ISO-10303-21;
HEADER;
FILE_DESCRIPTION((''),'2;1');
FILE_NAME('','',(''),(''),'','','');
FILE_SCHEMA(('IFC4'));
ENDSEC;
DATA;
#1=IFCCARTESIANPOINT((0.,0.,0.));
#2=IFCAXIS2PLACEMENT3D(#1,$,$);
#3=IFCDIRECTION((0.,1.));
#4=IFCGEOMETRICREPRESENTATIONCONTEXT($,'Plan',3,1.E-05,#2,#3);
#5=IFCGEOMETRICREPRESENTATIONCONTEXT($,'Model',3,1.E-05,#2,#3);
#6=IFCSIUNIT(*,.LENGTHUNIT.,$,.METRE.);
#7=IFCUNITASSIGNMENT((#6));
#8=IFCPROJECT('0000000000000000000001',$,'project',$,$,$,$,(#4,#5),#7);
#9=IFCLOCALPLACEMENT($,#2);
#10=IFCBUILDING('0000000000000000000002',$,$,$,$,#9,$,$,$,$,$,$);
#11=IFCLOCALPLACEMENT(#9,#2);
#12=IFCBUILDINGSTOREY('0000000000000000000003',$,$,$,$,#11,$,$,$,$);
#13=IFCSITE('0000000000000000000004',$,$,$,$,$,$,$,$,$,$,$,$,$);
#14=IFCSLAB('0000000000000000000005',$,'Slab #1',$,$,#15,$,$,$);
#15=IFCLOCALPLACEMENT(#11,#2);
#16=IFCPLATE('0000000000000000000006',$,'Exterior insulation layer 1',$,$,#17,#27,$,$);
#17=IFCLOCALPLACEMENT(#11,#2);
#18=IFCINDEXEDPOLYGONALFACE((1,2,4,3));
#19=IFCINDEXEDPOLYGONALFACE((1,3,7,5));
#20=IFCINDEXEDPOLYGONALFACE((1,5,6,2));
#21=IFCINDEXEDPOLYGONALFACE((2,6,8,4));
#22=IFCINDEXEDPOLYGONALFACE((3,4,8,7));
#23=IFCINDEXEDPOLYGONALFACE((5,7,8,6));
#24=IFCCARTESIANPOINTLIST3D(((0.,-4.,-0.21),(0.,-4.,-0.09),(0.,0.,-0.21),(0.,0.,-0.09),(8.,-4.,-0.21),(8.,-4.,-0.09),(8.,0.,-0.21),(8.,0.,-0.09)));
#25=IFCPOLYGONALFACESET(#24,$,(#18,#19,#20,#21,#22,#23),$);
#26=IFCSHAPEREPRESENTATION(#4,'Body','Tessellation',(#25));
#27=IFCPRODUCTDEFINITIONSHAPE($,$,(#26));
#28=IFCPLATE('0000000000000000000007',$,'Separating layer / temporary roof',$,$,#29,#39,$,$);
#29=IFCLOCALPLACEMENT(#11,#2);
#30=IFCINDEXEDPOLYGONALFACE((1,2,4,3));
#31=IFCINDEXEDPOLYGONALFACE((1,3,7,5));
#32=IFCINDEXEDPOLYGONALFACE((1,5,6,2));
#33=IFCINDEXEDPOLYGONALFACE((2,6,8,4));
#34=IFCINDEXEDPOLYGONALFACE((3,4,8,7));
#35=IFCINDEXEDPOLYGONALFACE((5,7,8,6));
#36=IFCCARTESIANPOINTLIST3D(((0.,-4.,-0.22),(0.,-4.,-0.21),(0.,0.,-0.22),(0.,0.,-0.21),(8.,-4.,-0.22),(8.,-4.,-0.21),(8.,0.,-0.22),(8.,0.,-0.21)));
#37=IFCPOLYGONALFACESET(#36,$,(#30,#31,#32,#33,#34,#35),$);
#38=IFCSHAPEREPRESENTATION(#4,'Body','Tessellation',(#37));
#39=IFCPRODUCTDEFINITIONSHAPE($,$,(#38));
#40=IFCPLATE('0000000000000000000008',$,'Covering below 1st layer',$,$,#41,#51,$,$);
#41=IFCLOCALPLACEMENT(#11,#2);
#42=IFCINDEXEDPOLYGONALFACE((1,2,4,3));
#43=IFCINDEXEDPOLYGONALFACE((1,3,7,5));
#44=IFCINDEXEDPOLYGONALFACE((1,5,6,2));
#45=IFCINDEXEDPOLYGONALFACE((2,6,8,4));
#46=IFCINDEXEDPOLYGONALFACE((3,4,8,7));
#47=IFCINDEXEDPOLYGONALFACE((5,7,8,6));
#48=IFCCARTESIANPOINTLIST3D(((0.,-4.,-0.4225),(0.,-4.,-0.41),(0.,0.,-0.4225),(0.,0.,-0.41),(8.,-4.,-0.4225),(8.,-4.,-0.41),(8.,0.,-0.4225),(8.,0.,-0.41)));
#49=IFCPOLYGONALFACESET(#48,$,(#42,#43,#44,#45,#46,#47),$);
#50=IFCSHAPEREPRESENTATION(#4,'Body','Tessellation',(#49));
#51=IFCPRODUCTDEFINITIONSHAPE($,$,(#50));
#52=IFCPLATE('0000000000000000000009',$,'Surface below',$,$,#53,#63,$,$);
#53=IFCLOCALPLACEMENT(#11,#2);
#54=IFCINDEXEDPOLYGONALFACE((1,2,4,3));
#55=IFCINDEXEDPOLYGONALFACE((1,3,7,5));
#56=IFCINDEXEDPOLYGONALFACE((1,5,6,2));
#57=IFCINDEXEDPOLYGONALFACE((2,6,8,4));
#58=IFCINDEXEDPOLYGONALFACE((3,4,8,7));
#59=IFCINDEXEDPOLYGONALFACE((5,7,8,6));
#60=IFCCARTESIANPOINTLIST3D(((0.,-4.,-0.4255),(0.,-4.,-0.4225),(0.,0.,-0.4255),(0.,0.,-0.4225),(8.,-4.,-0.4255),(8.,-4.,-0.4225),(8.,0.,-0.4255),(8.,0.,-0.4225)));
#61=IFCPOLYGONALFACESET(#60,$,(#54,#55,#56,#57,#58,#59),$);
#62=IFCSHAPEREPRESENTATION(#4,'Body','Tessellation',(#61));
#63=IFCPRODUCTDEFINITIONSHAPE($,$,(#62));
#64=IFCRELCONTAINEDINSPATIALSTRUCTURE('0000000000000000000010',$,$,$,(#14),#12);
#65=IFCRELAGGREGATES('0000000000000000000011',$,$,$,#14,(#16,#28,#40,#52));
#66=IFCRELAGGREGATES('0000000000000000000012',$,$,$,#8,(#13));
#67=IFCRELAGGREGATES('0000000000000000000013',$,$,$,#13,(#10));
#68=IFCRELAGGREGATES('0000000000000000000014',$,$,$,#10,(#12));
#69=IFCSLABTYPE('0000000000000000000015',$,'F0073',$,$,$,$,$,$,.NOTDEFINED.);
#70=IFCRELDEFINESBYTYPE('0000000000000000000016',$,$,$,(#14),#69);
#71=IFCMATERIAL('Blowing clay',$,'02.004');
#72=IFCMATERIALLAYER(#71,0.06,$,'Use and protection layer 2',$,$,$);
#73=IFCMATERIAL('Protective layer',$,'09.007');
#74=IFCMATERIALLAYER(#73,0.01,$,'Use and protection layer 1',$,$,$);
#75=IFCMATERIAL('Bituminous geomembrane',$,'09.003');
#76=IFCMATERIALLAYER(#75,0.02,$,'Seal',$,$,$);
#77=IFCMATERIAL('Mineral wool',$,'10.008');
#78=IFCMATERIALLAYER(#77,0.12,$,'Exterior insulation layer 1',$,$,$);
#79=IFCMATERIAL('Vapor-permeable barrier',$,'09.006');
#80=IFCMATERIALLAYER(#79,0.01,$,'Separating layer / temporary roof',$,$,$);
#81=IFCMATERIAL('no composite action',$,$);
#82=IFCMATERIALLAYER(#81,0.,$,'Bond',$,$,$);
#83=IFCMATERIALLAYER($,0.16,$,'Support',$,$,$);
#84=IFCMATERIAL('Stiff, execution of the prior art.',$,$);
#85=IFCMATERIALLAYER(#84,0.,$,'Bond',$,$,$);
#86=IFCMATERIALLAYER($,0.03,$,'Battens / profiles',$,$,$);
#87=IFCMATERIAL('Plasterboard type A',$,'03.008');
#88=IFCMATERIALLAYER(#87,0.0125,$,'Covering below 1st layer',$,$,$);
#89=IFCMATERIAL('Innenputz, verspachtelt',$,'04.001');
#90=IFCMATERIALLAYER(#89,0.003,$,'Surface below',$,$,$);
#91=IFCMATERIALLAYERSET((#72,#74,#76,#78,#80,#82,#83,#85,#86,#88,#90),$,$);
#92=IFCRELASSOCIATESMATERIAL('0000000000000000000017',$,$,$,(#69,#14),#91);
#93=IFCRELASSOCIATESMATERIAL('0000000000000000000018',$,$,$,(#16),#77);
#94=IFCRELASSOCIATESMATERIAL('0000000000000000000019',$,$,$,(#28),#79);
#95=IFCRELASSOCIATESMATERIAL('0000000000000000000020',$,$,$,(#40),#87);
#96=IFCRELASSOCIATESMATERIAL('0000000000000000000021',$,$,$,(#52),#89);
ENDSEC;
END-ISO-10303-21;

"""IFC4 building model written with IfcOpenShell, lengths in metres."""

from ifc_helpers import new_model, si_unit, direction, frame, frame_2d, origin, place, context, project, spatial, rectangle, extrude, material, layer, layer_set, type_object, element, aggregate, save


model = new_model("IFC4")

# Units and contexts
plan_context = context("Plan", 3, precision=1e-05, world=origin(), true_north=direction((0.0, 1.0)))
model_context = context("Model", 3, precision=1e-05, world=origin(), true_north=direction((0.0, 1.0)))
ifc_project = project(units=[si_unit("LENGTHUNIT", "METRE")], contexts=[plan_context, model_context])

# Site, building, storey
site = spatial("IfcSite", under=ifc_project)
building_placement = place(None, origin())
building = spatial("IfcBuilding", under=site, at=building_placement)
storey_placement = place(building_placement, origin())
storey = spatial("IfcBuildingStorey", under=building, at=storey_placement)

# Slab, plates
ifc_material_1 = material(Name="Blowing clay", Category="02.004")
ifc_layer_1 = layer(ifc_material_1, 0.06, Name="Use and protection layer 2")
ifc_material_2 = material(Name="Protective layer", Category="09.007")
ifc_layer_2 = layer(ifc_material_2, 0.01, Name="Use and protection layer 1")
ifc_material_3 = material(Name="Bituminous geomembrane", Category="09.003")
ifc_layer_3 = layer(ifc_material_3, 0.02, Name="Seal")
ifc_material_4 = material(Name="Mineral wool", Category="10.008")
ifc_layer_4 = layer(ifc_material_4, 0.12, Name="Exterior insulation layer 1")
ifc_material_5 = material(Name="Vapor-permeable barrier", Category="09.006")
ifc_layer_5 = layer(ifc_material_5, 0.01, Name="Separating layer / temporary roof")
ifc_material_6 = material(Name="no composite action")
ifc_layer_6 = layer(ifc_material_6, 0.0, Name="Bond")
ifc_layer_7 = layer(None, 0.16, Name="Support")
ifc_material_7 = material(Name="Stiff, execution of the prior art.")
ifc_layer_8 = layer(ifc_material_7, 0.0, Name="Bond")
ifc_layer_9 = layer(None, 0.03, Name="Battens / profiles")
ifc_material_8 = material(Name="Plasterboard type A", Category="03.008")
ifc_layer_10 = layer(ifc_material_8, 0.0125, Name="Covering below 1st layer")
ifc_material_9 = material(Name="Innenputz, verspachtelt", Category="04.001")
ifc_layer_11 = layer(ifc_material_9, 0.003, Name="Surface below")
ifc_layer_set = layer_set([ifc_layer_1, ifc_layer_2, ifc_layer_3, ifc_layer_4, ifc_layer_5, ifc_layer_6, ifc_layer_7, ifc_layer_8, ifc_layer_9, ifc_layer_10, ifc_layer_11])
slab_type = type_object("IfcSlabType", Name="F0073", PredefinedType="NOTDEFINED", material=ifc_layer_set)
slab_placement = place(None, frame((0.0, 0.0, 0.0), z_axis=(0.0, 0.0, -1.0), x_axis=(1.0, 0.0, 0.0)))
slab = element("IfcSlab", 1, at=slab_placement, inside=storey, type_object=slab_type, material=ifc_layer_set, Name="Slab #1")
plate_1_placement = place(slab_placement, origin())
plate_1 = element("IfcPlate", 2, at=plate_1_placement, material=ifc_material_4, Name="Exterior insulation layer 1", context=plan_context, shape_type="SweptSolid", body=[
    extrude(rectangle(XDim=8.0, YDim=4.0, at=frame_2d((4.0, 2.0), x_axis=(1.0, 0.0))), frame((0.0, 0.0, 0.09), z_axis=(0.0, 0.0, 1.0), x_axis=(1.0, 0.0, 0.0)), (0.0, 0.0, 1.0), 0.12),
])
plate_2_placement = place(slab_placement, origin())
plate_2 = element("IfcPlate", 3, at=plate_2_placement, material=ifc_material_5, Name="Separating layer / temporary roof", context=plan_context, shape_type="SweptSolid", body=[
    extrude(rectangle(XDim=8.0, YDim=4.0, at=frame_2d((4.0, 2.0), x_axis=(1.0, 0.0))), frame((0.0, 0.0, 0.21), z_axis=(0.0, 0.0, 1.0), x_axis=(1.0, 0.0, 0.0)), (0.0, 0.0, 1.0), 0.01),
])
plate_3_placement = place(slab_placement, origin())
plate_3 = element("IfcPlate", 4, at=plate_3_placement, material=ifc_material_8, Name="Covering below 1st layer", context=plan_context, shape_type="SweptSolid", body=[
    extrude(rectangle(XDim=8.0, YDim=4.0, at=frame_2d((4.0, 2.0), x_axis=(1.0, 0.0))), frame((0.0, 0.0, 0.41), z_axis=(0.0, 0.0, 1.0), x_axis=(1.0, 0.0, 0.0)), (0.0, 0.0, 1.0), 0.0125),
])
plate_4_placement = place(slab_placement, origin())
plate_4 = element("IfcPlate", 5, at=plate_4_placement, material=ifc_material_9, Name="Surface below", context=plan_context, shape_type="SweptSolid", body=[
    extrude(rectangle(XDim=8.0, YDim=4.0, at=frame_2d((4.0, 2.0), x_axis=(1.0, 0.0))), frame((0.0, 0.0, 0.4225), z_axis=(0.0, 0.0, 1.0), x_axis=(1.0, 0.0, 0.0)), (0.0, 0.0, 1.0), 0.003),
])
aggregate(slab, [plate_1, plate_2, plate_3, plate_4])

save(model, "model.ifc")
